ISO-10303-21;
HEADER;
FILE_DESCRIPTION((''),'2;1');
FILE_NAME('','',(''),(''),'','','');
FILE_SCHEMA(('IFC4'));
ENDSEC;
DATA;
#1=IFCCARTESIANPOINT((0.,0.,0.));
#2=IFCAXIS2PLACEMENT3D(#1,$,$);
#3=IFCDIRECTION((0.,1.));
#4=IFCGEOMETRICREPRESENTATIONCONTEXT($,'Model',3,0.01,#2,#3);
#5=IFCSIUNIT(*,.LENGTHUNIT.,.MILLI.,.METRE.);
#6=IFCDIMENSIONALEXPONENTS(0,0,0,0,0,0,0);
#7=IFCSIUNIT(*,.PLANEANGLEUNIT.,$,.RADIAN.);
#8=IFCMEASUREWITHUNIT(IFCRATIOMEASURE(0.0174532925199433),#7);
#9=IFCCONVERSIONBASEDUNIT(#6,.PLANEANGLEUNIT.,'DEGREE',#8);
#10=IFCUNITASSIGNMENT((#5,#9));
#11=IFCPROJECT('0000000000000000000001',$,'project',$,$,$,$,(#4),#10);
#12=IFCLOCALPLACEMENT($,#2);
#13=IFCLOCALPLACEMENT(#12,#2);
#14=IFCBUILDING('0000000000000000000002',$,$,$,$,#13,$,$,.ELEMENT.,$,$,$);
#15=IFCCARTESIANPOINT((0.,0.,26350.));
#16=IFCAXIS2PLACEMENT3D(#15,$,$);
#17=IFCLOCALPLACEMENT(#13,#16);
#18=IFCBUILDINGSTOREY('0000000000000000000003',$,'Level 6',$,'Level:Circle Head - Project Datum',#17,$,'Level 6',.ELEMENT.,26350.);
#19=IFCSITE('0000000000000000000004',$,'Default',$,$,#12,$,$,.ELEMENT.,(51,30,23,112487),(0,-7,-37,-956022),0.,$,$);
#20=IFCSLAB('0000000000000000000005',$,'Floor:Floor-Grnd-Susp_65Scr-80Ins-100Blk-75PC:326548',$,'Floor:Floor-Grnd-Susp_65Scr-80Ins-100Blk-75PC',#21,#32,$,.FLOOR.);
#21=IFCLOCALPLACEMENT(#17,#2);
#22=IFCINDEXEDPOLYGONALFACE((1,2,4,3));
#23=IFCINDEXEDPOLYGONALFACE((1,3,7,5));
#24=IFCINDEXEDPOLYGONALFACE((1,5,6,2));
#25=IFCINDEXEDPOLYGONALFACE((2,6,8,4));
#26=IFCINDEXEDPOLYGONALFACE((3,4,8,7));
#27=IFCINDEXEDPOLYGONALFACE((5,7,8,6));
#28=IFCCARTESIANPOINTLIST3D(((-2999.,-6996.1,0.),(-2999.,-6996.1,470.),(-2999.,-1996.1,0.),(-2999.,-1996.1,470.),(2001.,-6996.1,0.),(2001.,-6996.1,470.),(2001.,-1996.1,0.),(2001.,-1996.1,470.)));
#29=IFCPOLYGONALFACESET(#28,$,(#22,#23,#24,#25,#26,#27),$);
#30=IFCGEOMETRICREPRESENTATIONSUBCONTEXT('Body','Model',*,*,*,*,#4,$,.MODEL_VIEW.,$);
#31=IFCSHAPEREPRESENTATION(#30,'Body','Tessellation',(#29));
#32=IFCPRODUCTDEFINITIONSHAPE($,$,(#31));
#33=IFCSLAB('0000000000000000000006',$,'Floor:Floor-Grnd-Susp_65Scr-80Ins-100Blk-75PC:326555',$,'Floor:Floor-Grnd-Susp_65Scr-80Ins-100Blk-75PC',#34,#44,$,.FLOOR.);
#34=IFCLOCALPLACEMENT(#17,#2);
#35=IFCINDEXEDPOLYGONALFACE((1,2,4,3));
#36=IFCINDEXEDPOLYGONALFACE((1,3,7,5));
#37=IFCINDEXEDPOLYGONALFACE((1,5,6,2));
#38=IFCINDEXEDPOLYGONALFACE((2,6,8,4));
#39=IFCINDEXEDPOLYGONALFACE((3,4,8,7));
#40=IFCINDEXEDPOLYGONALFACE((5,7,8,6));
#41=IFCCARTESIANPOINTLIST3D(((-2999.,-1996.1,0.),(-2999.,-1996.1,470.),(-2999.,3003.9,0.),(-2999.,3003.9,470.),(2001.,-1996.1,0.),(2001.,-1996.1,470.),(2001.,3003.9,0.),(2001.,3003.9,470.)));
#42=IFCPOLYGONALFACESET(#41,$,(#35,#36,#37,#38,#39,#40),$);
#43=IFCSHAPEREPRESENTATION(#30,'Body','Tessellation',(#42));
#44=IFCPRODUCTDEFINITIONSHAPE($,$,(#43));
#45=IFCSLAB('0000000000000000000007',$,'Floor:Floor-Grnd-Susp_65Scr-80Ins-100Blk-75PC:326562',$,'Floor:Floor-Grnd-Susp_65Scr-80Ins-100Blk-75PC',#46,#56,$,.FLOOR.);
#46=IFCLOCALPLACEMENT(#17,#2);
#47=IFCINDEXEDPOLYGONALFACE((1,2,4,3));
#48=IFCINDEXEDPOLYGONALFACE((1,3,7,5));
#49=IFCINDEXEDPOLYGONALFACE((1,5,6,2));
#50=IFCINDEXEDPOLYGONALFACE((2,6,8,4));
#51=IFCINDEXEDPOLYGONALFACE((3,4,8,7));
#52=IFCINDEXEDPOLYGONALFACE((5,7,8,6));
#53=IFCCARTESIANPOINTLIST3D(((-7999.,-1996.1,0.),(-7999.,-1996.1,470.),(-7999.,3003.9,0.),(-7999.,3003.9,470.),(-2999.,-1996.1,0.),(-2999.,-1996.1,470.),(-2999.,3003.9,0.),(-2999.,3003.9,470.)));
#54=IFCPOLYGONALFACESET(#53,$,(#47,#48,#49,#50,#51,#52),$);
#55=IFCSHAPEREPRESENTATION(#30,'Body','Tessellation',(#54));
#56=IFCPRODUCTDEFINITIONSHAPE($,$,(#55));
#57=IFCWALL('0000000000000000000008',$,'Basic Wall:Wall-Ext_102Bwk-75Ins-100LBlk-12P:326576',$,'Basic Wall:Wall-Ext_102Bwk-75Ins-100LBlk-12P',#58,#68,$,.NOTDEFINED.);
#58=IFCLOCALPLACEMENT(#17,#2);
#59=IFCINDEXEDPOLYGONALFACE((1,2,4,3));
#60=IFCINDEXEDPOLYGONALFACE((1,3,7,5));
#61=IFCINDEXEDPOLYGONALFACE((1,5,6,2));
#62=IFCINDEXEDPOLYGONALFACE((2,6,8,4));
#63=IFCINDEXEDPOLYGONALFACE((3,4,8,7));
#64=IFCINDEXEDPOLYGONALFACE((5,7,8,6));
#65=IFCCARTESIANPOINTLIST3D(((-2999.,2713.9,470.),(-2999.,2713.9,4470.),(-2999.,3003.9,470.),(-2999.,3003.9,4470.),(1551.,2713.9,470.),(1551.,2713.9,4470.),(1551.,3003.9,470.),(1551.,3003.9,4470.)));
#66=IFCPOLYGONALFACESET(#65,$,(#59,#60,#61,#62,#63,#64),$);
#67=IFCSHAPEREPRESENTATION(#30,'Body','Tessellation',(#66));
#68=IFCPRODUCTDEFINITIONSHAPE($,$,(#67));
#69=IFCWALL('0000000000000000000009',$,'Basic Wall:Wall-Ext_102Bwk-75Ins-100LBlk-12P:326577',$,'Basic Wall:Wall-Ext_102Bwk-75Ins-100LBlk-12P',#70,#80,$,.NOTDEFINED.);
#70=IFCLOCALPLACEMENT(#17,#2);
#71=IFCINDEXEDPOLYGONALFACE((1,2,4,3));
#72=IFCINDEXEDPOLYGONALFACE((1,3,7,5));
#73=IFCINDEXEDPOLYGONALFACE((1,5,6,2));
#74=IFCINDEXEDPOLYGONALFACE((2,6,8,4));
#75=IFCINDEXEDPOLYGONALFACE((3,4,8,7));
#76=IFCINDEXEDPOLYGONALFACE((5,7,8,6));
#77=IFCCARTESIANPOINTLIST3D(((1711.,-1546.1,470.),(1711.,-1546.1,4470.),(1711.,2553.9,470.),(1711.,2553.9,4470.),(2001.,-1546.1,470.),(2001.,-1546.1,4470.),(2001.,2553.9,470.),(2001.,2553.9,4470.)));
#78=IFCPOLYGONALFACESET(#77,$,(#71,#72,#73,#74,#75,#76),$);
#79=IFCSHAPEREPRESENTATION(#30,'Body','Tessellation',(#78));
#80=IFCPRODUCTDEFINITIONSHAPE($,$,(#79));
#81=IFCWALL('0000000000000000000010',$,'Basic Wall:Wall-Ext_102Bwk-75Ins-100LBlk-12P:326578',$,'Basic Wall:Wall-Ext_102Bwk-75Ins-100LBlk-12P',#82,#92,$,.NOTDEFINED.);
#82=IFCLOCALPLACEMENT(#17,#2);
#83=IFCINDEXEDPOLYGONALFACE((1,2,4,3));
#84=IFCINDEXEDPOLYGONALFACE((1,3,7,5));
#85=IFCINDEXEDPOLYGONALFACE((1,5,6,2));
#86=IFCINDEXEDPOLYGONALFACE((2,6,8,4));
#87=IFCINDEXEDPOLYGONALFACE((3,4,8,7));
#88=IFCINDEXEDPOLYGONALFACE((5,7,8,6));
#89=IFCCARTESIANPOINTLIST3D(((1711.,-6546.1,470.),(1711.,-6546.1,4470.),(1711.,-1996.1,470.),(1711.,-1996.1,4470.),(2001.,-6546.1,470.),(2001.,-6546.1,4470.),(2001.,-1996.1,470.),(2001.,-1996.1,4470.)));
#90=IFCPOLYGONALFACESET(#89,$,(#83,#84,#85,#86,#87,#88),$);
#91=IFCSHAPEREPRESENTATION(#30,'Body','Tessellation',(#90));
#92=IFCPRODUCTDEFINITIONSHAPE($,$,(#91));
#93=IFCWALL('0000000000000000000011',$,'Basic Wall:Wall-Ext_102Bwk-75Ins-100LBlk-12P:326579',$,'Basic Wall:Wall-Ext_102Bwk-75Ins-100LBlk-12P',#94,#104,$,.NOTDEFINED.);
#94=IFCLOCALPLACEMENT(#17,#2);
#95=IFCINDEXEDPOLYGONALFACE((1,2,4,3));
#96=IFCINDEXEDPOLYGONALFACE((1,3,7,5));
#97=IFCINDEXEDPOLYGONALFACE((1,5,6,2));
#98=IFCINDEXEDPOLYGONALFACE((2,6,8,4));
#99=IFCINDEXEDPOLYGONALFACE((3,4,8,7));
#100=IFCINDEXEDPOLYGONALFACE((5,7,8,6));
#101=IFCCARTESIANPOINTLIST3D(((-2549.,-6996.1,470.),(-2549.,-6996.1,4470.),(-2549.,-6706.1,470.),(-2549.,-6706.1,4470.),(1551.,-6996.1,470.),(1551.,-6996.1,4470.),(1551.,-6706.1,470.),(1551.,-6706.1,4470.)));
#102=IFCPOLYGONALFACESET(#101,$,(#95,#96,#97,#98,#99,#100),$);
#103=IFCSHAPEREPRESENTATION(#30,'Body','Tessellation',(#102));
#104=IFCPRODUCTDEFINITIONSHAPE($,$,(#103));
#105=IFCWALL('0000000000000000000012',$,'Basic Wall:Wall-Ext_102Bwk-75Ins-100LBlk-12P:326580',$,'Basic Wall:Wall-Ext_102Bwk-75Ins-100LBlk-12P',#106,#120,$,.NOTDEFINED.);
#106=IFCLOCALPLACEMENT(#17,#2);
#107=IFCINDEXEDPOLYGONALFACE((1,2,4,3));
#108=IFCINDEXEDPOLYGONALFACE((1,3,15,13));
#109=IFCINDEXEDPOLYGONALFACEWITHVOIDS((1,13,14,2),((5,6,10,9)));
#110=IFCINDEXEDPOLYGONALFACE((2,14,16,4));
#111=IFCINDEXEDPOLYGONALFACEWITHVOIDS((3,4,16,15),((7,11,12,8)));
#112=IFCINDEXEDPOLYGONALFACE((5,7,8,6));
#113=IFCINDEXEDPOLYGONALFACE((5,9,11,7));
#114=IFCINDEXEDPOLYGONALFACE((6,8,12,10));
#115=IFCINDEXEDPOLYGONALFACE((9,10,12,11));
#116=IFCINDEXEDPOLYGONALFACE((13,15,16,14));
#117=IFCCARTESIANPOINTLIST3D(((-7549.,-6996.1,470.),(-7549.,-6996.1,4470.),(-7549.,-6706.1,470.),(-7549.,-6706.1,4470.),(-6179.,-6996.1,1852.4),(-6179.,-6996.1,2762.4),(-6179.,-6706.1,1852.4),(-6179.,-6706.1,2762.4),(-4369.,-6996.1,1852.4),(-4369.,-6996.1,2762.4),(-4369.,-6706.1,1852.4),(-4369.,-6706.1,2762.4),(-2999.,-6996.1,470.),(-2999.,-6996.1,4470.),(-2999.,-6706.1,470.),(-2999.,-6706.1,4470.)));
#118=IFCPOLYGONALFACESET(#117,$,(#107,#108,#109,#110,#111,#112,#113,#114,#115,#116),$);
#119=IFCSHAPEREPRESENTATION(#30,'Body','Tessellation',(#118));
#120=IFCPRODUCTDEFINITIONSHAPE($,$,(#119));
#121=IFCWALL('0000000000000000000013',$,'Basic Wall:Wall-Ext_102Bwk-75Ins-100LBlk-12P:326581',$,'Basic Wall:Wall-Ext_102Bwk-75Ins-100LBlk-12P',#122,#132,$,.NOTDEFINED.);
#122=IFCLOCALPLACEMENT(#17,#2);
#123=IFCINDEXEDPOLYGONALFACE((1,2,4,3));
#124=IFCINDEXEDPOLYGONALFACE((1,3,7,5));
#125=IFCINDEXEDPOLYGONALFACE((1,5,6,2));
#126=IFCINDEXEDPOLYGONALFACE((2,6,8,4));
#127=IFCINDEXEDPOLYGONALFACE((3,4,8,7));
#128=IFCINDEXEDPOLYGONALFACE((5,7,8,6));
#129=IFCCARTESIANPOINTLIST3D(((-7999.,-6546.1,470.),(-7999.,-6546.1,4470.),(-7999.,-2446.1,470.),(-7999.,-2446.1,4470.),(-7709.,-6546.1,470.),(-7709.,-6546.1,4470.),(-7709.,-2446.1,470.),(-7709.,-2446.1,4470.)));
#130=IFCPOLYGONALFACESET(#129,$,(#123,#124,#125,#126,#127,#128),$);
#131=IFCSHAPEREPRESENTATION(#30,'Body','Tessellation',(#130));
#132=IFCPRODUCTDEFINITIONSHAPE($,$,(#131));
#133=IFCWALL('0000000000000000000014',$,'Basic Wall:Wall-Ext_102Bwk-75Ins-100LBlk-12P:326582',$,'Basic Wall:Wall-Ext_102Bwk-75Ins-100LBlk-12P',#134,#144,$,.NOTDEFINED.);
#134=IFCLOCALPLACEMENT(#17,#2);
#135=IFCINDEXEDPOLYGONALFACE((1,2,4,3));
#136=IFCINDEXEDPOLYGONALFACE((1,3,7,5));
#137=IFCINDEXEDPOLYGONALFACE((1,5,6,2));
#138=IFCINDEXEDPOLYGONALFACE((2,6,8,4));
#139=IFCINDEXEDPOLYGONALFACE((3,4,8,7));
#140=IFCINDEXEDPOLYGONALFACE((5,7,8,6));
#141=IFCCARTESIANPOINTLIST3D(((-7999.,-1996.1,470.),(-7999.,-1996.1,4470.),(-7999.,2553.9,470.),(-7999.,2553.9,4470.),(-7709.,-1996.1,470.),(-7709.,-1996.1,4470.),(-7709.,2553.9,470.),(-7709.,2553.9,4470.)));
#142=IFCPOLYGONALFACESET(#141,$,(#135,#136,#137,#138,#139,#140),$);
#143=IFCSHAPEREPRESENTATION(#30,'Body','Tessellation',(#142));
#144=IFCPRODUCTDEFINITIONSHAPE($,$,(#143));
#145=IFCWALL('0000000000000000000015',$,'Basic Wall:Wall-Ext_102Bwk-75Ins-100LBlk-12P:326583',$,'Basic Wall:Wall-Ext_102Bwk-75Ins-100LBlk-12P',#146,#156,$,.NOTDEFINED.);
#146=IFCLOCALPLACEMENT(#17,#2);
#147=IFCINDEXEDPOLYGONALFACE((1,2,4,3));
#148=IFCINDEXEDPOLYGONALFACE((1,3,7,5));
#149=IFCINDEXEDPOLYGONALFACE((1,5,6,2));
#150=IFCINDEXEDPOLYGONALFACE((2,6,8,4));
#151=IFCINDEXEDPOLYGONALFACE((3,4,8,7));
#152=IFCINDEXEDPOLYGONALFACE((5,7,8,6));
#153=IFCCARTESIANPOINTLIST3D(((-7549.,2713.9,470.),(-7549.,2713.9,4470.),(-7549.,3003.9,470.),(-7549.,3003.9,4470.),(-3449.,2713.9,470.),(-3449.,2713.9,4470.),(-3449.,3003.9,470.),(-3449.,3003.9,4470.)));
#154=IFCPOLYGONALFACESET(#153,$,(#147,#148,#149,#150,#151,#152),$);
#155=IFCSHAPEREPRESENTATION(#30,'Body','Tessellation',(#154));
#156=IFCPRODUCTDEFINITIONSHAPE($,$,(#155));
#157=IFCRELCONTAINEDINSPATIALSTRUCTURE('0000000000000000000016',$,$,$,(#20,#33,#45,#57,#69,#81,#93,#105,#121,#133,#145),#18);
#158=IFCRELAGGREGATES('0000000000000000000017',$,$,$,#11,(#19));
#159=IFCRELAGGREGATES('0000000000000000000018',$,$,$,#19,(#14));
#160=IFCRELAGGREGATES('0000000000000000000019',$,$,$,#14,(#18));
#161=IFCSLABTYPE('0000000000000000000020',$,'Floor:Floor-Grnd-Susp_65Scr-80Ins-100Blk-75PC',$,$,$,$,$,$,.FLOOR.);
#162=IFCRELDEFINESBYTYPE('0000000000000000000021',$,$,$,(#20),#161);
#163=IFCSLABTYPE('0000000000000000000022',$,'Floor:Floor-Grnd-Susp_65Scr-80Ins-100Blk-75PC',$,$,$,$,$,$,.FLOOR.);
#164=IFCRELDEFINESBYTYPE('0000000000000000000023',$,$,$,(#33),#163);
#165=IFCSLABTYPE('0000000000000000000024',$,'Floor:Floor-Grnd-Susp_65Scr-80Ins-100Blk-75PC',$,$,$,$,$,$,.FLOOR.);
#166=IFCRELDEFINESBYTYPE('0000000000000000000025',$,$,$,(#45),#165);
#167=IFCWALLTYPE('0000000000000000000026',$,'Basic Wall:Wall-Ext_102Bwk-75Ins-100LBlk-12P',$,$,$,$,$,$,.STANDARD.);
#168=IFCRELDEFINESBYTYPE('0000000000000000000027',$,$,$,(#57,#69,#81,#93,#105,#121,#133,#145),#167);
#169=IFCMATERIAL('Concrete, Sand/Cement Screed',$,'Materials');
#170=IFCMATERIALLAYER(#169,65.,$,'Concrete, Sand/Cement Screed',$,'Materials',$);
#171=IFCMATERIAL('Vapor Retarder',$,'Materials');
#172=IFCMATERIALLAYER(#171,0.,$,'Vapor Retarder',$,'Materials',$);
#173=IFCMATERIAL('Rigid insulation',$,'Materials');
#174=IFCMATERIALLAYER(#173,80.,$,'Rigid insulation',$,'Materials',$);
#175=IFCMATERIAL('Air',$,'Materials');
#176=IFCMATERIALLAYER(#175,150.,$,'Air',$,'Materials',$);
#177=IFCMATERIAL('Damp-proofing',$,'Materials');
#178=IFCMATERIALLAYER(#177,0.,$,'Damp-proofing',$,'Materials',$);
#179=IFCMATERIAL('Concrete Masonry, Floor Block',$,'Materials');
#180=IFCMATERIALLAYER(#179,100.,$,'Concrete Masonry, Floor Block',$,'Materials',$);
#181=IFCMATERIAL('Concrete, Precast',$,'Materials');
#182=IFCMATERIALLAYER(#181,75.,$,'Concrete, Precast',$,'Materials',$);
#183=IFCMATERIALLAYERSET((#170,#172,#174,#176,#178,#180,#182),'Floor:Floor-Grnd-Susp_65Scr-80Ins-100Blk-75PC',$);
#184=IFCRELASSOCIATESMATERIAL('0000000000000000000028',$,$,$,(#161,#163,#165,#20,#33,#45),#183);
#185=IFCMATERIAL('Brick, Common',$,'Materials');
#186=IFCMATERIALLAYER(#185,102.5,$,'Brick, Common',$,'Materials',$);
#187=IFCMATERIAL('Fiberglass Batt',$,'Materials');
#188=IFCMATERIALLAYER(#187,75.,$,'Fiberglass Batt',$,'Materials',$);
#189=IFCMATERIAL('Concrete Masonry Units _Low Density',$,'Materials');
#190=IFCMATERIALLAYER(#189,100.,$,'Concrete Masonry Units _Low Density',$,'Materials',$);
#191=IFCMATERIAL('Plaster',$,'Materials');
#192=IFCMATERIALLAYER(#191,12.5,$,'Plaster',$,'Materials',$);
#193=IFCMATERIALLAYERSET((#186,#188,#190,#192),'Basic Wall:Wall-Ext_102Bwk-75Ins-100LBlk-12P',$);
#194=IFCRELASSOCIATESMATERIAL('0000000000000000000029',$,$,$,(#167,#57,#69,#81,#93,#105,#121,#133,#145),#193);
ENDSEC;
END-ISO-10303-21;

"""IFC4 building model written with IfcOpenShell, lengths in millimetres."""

from ifc_helpers import new_model, entity, si_unit, converted_unit, direction, frame, frame_2d, origin, origin_2d_with_axis, place, context, subcontext, project, spatial, rectangle, extrude, material, layer, layer_set, layer_usage, type_object, element, save


model = new_model("IFC4")

# Units and contexts
model_context = context("Model", 3, precision=0.01, world=origin(), true_north=direction((0.0, 1.0)))
body_context = subcontext(model_context, "Body", "Model", "MODEL_VIEW")
ifc_project = project(units=[si_unit("LENGTHUNIT", "METRE", prefix="MILLI"), converted_unit("PLANEANGLEUNIT", "DEGREE", entity("IfcRatioMeasure", 0.0174532925199433), si_unit("PLANEANGLEUNIT", "RADIAN"), dimensions=[0, 0, 0, 0, 0, 0, 0])], contexts=[model_context])

# Site, building, storey
site_placement = place(None, origin())
site = spatial("IfcSite", under=ifc_project, at=site_placement, Name="Default", CompositionType="ELEMENT", RefLatitude=(51, 30, 23, 112487), RefLongitude=(0, -7, -37, -956022), RefElevation=0.0)
building_placement = place(site_placement, origin())
building = spatial("IfcBuilding", under=site, at=building_placement, CompositionType="ELEMENT")
storey_placement = place(building_placement, frame((0.0, 0.0, 26350.0)))
storey = spatial("IfcBuildingStorey", under=building, at=storey_placement, Name="Level 6", ObjectType="Level:Circle Head - Project Datum", LongName="Level 6", CompositionType="ELEMENT", Elevation=26350.0)

# Slabs
ifc_material_1 = material(Name="Concrete, Sand/Cement Screed", Category="Materials")
ifc_layer_1 = layer(ifc_material_1, 65.0, Name="Concrete, Sand/Cement Screed", Category="Materials")
ifc_material_2 = material(Name="Vapor Retarder", Category="Materials")
ifc_layer_2 = layer(ifc_material_2, 0.0, Name="Vapor Retarder", Category="Materials")
ifc_material_3 = material(Name="Rigid insulation", Category="Materials")
ifc_layer_3 = layer(ifc_material_3, 80.0, Name="Rigid insulation", Category="Materials")
ifc_material_4 = material(Name="Air", Category="Materials")
ifc_layer_4 = layer(ifc_material_4, 150.0, Name="Air", Category="Materials")
ifc_material_5 = material(Name="Damp-proofing", Category="Materials")
ifc_layer_5 = layer(ifc_material_5, 0.0, Name="Damp-proofing", Category="Materials")
ifc_material_6 = material(Name="Concrete Masonry, Floor Block", Category="Materials")
ifc_layer_6 = layer(ifc_material_6, 100.0, Name="Concrete Masonry, Floor Block", Category="Materials")
ifc_material_7 = material(Name="Concrete, Precast", Category="Materials")
ifc_layer_7 = layer(ifc_material_7, 75.0, Name="Concrete, Precast", Category="Materials")
ifc_layer_set_1 = layer_set([ifc_layer_1, ifc_layer_2, ifc_layer_3, ifc_layer_4, ifc_layer_5, ifc_layer_6, ifc_layer_7], Name="Floor:Floor-Grnd-Susp_65Scr-80Ins-100Blk-75PC")
ifc_layer_usage_1 = layer_usage(ifc_layer_set_1, "AXIS3", "POSITIVE", 0.0)
slab_type_1 = type_object("IfcSlabType", Name="Floor:Floor-Grnd-Susp_65Scr-80Ins-100Blk-75PC", PredefinedType="FLOOR", material=ifc_layer_set_1)
slab_1_placement = place(storey_placement, origin())
element("IfcSlab", 1, at=slab_1_placement, inside=storey, type_object=slab_type_1, material=ifc_layer_usage_1, Name="Floor:Floor-Grnd-Susp_65Scr-80Ins-100Blk-75PC:326548", ObjectType="Floor:Floor-Grnd-Susp_65Scr-80Ins-100Blk-75PC", PredefinedType="FLOOR", context=body_context, shape_type="SweptSolid", body=[
    extrude(rectangle(XDim=5000.0, YDim=5000.0, at=frame_2d((0.0, 0.0), x_axis=(1.0, 0.0))), frame((-499.0, -4496.1, 470.0), z_axis=(0.0, 0.0, -1.0), x_axis=(0.0, 1.0, 0.0)), (0.0, 0.0, 1.0), 470.0),
])
ifc_layer_usage_2 = layer_usage(ifc_layer_set_1, "AXIS3", "POSITIVE", 0.0)
slab_type_2 = type_object("IfcSlabType", Name="Floor:Floor-Grnd-Susp_65Scr-80Ins-100Blk-75PC", PredefinedType="FLOOR", material=ifc_layer_set_1)
slab_2_placement = place(storey_placement, origin())
element("IfcSlab", 2, at=slab_2_placement, inside=storey, type_object=slab_type_2, material=ifc_layer_usage_2, Name="Floor:Floor-Grnd-Susp_65Scr-80Ins-100Blk-75PC:326555", ObjectType="Floor:Floor-Grnd-Susp_65Scr-80Ins-100Blk-75PC", PredefinedType="FLOOR", context=body_context, shape_type="SweptSolid", body=[
    extrude(rectangle(XDim=5000.0, YDim=5000.0, at=origin_2d_with_axis()), frame((-499.0, 503.9, 470.0), z_axis=(0.0, 0.0, -1.0), x_axis=(0.0, 1.0, 0.0)), (0.0, 0.0, 1.0), 470.0),
])
ifc_layer_usage_3 = layer_usage(ifc_layer_set_1, "AXIS3", "POSITIVE", 0.0)
slab_type_3 = type_object("IfcSlabType", Name="Floor:Floor-Grnd-Susp_65Scr-80Ins-100Blk-75PC", PredefinedType="FLOOR", material=ifc_layer_set_1)
slab_3_placement = place(storey_placement, origin())
element("IfcSlab", 3, at=slab_3_placement, inside=storey, type_object=slab_type_3, material=ifc_layer_usage_3, Name="Floor:Floor-Grnd-Susp_65Scr-80Ins-100Blk-75PC:326562", ObjectType="Floor:Floor-Grnd-Susp_65Scr-80Ins-100Blk-75PC", PredefinedType="FLOOR", context=body_context, shape_type="SweptSolid", body=[
    extrude(rectangle(XDim=5000.0, YDim=5000.0, at=origin_2d_with_axis()), frame((-5499.0, 503.9, 470.0), z_axis=(0.0, 0.0, -1.0), x_axis=(0.0, 1.0, 0.0)), (0.0, 0.0, 1.0), 470.0),
])

# Walls
ifc_material_8 = material(Name="Brick, Common", Category="Materials")
ifc_layer_8 = layer(ifc_material_8, 102.5, Name="Brick, Common", Category="Materials")
ifc_material_9 = material(Name="Fiberglass Batt", Category="Materials")
ifc_layer_9 = layer(ifc_material_9, 75.0, Name="Fiberglass Batt", Category="Materials")
ifc_material_10 = material(Name="Concrete Masonry Units _Low Density", Category="Materials")
ifc_layer_10 = layer(ifc_material_10, 100.0, Name="Concrete Masonry Units _Low Density", Category="Materials")
ifc_material_11 = material(Name="Plaster", Category="Materials")
ifc_layer_11 = layer(ifc_material_11, 12.5, Name="Plaster", Category="Materials")
ifc_layer_set_2 = layer_set([ifc_layer_8, ifc_layer_9, ifc_layer_10, ifc_layer_11], Name="Basic Wall:Wall-Ext_102Bwk-75Ins-100LBlk-12P")
ifc_layer_usage_4 = layer_usage(ifc_layer_set_2, "AXIS2", "NEGATIVE", 145.0)
wall_type = type_object("IfcWallType", Name="Basic Wall:Wall-Ext_102Bwk-75Ins-100LBlk-12P", PredefinedType="STANDARD", material=ifc_layer_set_2)
wall_1_placement = place(storey_placement, frame((-2999.0, 2858.9, 470.0)))
element("IfcWall", 4, at=wall_1_placement, inside=storey, type_object=wall_type, material=ifc_layer_usage_4, Name="Basic Wall:Wall-Ext_102Bwk-75Ins-100LBlk-12P:326576", ObjectType="Basic Wall:Wall-Ext_102Bwk-75Ins-100LBlk-12P", PredefinedType="NOTDEFINED", context=body_context, shape_type="SweptSolid", body=[
    extrude(rectangle(XDim=4550.0, YDim=290.0, at=frame_2d((2275.0, 0.0), x_axis=(-1.0, 0.0))), origin(), (0.0, 0.0, 1.0), 4000.0),
])
ifc_layer_usage_5 = layer_usage(ifc_layer_set_2, "AXIS2", "NEGATIVE", 145.0)
wall_2_placement = place(storey_placement, frame((1856.0, 2553.9, 470.0), z_axis=(0.0, 0.0, 1.0), x_axis=(0.0, -1.0, 0.0)))
element("IfcWall", 5, at=wall_2_placement, inside=storey, type_object=wall_type, material=ifc_layer_usage_5, Name="Basic Wall:Wall-Ext_102Bwk-75Ins-100LBlk-12P:326577", ObjectType="Basic Wall:Wall-Ext_102Bwk-75Ins-100LBlk-12P", PredefinedType="NOTDEFINED", context=body_context, shape_type="SweptSolid", body=[
    extrude(rectangle(XDim=4100.0, YDim=290.0, at=frame_2d((2050.0, 0.0), x_axis=(-1.0, 0.0))), origin(), (0.0, 0.0, 1.0), 4000.0),
])
ifc_layer_usage_6 = layer_usage(ifc_layer_set_2, "AXIS2", "NEGATIVE", 145.0)
wall_3_placement = place(storey_placement, frame((1856.0, -1996.1, 470.0), z_axis=(0.0, 0.0, 1.0), x_axis=(0.0, -1.0, 0.0)))
element("IfcWall", 6, at=wall_3_placement, inside=storey, type_object=wall_type, material=ifc_layer_usage_6, Name="Basic Wall:Wall-Ext_102Bwk-75Ins-100LBlk-12P:326578", ObjectType="Basic Wall:Wall-Ext_102Bwk-75Ins-100LBlk-12P", PredefinedType="NOTDEFINED", context=body_context, shape_type="SweptSolid", body=[
    extrude(rectangle(XDim=4550.0, YDim=290.0, at=frame_2d((2275.0, 0.0), x_axis=(-1.0, 0.0))), origin(), (0.0, 0.0, 1.0), 4000.0),
])
ifc_layer_usage_7 = layer_usage(ifc_layer_set_2, "AXIS2", "NEGATIVE", 145.0)
wall_4_placement = place(storey_placement, frame((1551.0, -6851.1, 470.0), z_axis=(0.0, 0.0, 1.0), x_axis=(-1.0, 0.0, 0.0)))
element("IfcWall", 7, at=wall_4_placement, inside=storey, type_object=wall_type, material=ifc_layer_usage_7, Name="Basic Wall:Wall-Ext_102Bwk-75Ins-100LBlk-12P:326579", ObjectType="Basic Wall:Wall-Ext_102Bwk-75Ins-100LBlk-12P", PredefinedType="NOTDEFINED", context=body_context, shape_type="SweptSolid", body=[
    extrude(rectangle(XDim=4100.0, YDim=290.0, at=frame_2d((2050.0, 0.0), x_axis=(-1.0, 0.0))), origin(), (0.0, 0.0, 1.0), 4000.0),
])

# Wall, opening
ifc_layer_usage_8 = layer_usage(ifc_layer_set_2, "AXIS2", "NEGATIVE", 145.0)
wall_5_placement = place(storey_placement, frame((-2999.0, -6851.1, 470.0), z_axis=(0.0, 0.0, 1.0), x_axis=(-1.0, 0.0, 0.0)))
wall_5 = element("IfcWall", 8, at=wall_5_placement, inside=storey, type_object=wall_type, material=ifc_layer_usage_8, Name="Basic Wall:Wall-Ext_102Bwk-75Ins-100LBlk-12P:326580", ObjectType="Basic Wall:Wall-Ext_102Bwk-75Ins-100LBlk-12P", PredefinedType="NOTDEFINED", context=body_context, shape_type="SweptSolid", body=[
    extrude(rectangle(XDim=4550.0, YDim=290.0, at=frame_2d((2275.0, 0.0), x_axis=(-1.0, 0.0))), origin(), (0.0, 0.0, 1.0), 4000.0),
])
opening_placement = place(wall_5_placement, frame((1370.0, -145.0, 1382.4)))
element("IfcOpeningElement", 9, at=opening_placement, cuts=wall_5, PredefinedType="OPENING", context=body_context, shape_type="SweptSolid", body=[
    extrude(rectangle(XDim=910.0, YDim=1810.0, at=frame_2d((455.0, 905.0), x_axis=(-1.0, 0.0))), frame((0.0, 0.0, 0.0), z_axis=(0.0, 1.0, 0.0), x_axis=(0.0, 0.0, 1.0)), (0.0, 0.0, 1.0), 290.0),
])

# Walls
ifc_layer_usage_9 = layer_usage(ifc_layer_set_2, "AXIS2", "NEGATIVE", 145.0)
wall_6_placement = place(storey_placement, frame((-7854.0, -6546.1, 470.0), z_axis=(0.0, 0.0, 1.0), x_axis=(0.0, 1.0, 0.0)))
element("IfcWall", 10, at=wall_6_placement, inside=storey, type_object=wall_type, material=ifc_layer_usage_9, Name="Basic Wall:Wall-Ext_102Bwk-75Ins-100LBlk-12P:326581", ObjectType="Basic Wall:Wall-Ext_102Bwk-75Ins-100LBlk-12P", PredefinedType="NOTDEFINED", context=body_context, shape_type="SweptSolid", body=[
    extrude(rectangle(XDim=4100.0, YDim=290.0, at=frame_2d((2050.0, 0.0), x_axis=(-1.0, 0.0))), origin(), (0.0, 0.0, 1.0), 4000.0),
])
ifc_layer_usage_10 = layer_usage(ifc_layer_set_2, "AXIS2", "NEGATIVE", 145.0)
wall_7_placement = place(storey_placement, frame((-7854.0, -1996.1, 470.0), z_axis=(0.0, 0.0, 1.0), x_axis=(0.0, 1.0, 0.0)))
element("IfcWall", 11, at=wall_7_placement, inside=storey, type_object=wall_type, material=ifc_layer_usage_10, Name="Basic Wall:Wall-Ext_102Bwk-75Ins-100LBlk-12P:326582", ObjectType="Basic Wall:Wall-Ext_102Bwk-75Ins-100LBlk-12P", PredefinedType="NOTDEFINED", context=body_context, shape_type="SweptSolid", body=[
    extrude(rectangle(XDim=4550.0, YDim=290.0, at=frame_2d((2275.0, 0.0), x_axis=(-1.0, 0.0))), origin(), (0.0, 0.0, 1.0), 4000.0),
])
ifc_layer_usage_11 = layer_usage(ifc_layer_set_2, "AXIS2", "NEGATIVE", 145.0)
wall_8_placement = place(storey_placement, frame((-7549.0, 2858.9, 470.0)))
element("IfcWall", 12, at=wall_8_placement, inside=storey, type_object=wall_type, material=ifc_layer_usage_11, Name="Basic Wall:Wall-Ext_102Bwk-75Ins-100LBlk-12P:326583", ObjectType="Basic Wall:Wall-Ext_102Bwk-75Ins-100LBlk-12P", PredefinedType="NOTDEFINED", context=body_context, shape_type="SweptSolid", body=[
    extrude(rectangle(XDim=4100.0, YDim=290.0, at=frame_2d((2050.0, 0.0), x_axis=(-1.0, 0.0))), origin(), (0.0, 0.0, 1.0), 4000.0),
])

save(model, "model.ifc")
